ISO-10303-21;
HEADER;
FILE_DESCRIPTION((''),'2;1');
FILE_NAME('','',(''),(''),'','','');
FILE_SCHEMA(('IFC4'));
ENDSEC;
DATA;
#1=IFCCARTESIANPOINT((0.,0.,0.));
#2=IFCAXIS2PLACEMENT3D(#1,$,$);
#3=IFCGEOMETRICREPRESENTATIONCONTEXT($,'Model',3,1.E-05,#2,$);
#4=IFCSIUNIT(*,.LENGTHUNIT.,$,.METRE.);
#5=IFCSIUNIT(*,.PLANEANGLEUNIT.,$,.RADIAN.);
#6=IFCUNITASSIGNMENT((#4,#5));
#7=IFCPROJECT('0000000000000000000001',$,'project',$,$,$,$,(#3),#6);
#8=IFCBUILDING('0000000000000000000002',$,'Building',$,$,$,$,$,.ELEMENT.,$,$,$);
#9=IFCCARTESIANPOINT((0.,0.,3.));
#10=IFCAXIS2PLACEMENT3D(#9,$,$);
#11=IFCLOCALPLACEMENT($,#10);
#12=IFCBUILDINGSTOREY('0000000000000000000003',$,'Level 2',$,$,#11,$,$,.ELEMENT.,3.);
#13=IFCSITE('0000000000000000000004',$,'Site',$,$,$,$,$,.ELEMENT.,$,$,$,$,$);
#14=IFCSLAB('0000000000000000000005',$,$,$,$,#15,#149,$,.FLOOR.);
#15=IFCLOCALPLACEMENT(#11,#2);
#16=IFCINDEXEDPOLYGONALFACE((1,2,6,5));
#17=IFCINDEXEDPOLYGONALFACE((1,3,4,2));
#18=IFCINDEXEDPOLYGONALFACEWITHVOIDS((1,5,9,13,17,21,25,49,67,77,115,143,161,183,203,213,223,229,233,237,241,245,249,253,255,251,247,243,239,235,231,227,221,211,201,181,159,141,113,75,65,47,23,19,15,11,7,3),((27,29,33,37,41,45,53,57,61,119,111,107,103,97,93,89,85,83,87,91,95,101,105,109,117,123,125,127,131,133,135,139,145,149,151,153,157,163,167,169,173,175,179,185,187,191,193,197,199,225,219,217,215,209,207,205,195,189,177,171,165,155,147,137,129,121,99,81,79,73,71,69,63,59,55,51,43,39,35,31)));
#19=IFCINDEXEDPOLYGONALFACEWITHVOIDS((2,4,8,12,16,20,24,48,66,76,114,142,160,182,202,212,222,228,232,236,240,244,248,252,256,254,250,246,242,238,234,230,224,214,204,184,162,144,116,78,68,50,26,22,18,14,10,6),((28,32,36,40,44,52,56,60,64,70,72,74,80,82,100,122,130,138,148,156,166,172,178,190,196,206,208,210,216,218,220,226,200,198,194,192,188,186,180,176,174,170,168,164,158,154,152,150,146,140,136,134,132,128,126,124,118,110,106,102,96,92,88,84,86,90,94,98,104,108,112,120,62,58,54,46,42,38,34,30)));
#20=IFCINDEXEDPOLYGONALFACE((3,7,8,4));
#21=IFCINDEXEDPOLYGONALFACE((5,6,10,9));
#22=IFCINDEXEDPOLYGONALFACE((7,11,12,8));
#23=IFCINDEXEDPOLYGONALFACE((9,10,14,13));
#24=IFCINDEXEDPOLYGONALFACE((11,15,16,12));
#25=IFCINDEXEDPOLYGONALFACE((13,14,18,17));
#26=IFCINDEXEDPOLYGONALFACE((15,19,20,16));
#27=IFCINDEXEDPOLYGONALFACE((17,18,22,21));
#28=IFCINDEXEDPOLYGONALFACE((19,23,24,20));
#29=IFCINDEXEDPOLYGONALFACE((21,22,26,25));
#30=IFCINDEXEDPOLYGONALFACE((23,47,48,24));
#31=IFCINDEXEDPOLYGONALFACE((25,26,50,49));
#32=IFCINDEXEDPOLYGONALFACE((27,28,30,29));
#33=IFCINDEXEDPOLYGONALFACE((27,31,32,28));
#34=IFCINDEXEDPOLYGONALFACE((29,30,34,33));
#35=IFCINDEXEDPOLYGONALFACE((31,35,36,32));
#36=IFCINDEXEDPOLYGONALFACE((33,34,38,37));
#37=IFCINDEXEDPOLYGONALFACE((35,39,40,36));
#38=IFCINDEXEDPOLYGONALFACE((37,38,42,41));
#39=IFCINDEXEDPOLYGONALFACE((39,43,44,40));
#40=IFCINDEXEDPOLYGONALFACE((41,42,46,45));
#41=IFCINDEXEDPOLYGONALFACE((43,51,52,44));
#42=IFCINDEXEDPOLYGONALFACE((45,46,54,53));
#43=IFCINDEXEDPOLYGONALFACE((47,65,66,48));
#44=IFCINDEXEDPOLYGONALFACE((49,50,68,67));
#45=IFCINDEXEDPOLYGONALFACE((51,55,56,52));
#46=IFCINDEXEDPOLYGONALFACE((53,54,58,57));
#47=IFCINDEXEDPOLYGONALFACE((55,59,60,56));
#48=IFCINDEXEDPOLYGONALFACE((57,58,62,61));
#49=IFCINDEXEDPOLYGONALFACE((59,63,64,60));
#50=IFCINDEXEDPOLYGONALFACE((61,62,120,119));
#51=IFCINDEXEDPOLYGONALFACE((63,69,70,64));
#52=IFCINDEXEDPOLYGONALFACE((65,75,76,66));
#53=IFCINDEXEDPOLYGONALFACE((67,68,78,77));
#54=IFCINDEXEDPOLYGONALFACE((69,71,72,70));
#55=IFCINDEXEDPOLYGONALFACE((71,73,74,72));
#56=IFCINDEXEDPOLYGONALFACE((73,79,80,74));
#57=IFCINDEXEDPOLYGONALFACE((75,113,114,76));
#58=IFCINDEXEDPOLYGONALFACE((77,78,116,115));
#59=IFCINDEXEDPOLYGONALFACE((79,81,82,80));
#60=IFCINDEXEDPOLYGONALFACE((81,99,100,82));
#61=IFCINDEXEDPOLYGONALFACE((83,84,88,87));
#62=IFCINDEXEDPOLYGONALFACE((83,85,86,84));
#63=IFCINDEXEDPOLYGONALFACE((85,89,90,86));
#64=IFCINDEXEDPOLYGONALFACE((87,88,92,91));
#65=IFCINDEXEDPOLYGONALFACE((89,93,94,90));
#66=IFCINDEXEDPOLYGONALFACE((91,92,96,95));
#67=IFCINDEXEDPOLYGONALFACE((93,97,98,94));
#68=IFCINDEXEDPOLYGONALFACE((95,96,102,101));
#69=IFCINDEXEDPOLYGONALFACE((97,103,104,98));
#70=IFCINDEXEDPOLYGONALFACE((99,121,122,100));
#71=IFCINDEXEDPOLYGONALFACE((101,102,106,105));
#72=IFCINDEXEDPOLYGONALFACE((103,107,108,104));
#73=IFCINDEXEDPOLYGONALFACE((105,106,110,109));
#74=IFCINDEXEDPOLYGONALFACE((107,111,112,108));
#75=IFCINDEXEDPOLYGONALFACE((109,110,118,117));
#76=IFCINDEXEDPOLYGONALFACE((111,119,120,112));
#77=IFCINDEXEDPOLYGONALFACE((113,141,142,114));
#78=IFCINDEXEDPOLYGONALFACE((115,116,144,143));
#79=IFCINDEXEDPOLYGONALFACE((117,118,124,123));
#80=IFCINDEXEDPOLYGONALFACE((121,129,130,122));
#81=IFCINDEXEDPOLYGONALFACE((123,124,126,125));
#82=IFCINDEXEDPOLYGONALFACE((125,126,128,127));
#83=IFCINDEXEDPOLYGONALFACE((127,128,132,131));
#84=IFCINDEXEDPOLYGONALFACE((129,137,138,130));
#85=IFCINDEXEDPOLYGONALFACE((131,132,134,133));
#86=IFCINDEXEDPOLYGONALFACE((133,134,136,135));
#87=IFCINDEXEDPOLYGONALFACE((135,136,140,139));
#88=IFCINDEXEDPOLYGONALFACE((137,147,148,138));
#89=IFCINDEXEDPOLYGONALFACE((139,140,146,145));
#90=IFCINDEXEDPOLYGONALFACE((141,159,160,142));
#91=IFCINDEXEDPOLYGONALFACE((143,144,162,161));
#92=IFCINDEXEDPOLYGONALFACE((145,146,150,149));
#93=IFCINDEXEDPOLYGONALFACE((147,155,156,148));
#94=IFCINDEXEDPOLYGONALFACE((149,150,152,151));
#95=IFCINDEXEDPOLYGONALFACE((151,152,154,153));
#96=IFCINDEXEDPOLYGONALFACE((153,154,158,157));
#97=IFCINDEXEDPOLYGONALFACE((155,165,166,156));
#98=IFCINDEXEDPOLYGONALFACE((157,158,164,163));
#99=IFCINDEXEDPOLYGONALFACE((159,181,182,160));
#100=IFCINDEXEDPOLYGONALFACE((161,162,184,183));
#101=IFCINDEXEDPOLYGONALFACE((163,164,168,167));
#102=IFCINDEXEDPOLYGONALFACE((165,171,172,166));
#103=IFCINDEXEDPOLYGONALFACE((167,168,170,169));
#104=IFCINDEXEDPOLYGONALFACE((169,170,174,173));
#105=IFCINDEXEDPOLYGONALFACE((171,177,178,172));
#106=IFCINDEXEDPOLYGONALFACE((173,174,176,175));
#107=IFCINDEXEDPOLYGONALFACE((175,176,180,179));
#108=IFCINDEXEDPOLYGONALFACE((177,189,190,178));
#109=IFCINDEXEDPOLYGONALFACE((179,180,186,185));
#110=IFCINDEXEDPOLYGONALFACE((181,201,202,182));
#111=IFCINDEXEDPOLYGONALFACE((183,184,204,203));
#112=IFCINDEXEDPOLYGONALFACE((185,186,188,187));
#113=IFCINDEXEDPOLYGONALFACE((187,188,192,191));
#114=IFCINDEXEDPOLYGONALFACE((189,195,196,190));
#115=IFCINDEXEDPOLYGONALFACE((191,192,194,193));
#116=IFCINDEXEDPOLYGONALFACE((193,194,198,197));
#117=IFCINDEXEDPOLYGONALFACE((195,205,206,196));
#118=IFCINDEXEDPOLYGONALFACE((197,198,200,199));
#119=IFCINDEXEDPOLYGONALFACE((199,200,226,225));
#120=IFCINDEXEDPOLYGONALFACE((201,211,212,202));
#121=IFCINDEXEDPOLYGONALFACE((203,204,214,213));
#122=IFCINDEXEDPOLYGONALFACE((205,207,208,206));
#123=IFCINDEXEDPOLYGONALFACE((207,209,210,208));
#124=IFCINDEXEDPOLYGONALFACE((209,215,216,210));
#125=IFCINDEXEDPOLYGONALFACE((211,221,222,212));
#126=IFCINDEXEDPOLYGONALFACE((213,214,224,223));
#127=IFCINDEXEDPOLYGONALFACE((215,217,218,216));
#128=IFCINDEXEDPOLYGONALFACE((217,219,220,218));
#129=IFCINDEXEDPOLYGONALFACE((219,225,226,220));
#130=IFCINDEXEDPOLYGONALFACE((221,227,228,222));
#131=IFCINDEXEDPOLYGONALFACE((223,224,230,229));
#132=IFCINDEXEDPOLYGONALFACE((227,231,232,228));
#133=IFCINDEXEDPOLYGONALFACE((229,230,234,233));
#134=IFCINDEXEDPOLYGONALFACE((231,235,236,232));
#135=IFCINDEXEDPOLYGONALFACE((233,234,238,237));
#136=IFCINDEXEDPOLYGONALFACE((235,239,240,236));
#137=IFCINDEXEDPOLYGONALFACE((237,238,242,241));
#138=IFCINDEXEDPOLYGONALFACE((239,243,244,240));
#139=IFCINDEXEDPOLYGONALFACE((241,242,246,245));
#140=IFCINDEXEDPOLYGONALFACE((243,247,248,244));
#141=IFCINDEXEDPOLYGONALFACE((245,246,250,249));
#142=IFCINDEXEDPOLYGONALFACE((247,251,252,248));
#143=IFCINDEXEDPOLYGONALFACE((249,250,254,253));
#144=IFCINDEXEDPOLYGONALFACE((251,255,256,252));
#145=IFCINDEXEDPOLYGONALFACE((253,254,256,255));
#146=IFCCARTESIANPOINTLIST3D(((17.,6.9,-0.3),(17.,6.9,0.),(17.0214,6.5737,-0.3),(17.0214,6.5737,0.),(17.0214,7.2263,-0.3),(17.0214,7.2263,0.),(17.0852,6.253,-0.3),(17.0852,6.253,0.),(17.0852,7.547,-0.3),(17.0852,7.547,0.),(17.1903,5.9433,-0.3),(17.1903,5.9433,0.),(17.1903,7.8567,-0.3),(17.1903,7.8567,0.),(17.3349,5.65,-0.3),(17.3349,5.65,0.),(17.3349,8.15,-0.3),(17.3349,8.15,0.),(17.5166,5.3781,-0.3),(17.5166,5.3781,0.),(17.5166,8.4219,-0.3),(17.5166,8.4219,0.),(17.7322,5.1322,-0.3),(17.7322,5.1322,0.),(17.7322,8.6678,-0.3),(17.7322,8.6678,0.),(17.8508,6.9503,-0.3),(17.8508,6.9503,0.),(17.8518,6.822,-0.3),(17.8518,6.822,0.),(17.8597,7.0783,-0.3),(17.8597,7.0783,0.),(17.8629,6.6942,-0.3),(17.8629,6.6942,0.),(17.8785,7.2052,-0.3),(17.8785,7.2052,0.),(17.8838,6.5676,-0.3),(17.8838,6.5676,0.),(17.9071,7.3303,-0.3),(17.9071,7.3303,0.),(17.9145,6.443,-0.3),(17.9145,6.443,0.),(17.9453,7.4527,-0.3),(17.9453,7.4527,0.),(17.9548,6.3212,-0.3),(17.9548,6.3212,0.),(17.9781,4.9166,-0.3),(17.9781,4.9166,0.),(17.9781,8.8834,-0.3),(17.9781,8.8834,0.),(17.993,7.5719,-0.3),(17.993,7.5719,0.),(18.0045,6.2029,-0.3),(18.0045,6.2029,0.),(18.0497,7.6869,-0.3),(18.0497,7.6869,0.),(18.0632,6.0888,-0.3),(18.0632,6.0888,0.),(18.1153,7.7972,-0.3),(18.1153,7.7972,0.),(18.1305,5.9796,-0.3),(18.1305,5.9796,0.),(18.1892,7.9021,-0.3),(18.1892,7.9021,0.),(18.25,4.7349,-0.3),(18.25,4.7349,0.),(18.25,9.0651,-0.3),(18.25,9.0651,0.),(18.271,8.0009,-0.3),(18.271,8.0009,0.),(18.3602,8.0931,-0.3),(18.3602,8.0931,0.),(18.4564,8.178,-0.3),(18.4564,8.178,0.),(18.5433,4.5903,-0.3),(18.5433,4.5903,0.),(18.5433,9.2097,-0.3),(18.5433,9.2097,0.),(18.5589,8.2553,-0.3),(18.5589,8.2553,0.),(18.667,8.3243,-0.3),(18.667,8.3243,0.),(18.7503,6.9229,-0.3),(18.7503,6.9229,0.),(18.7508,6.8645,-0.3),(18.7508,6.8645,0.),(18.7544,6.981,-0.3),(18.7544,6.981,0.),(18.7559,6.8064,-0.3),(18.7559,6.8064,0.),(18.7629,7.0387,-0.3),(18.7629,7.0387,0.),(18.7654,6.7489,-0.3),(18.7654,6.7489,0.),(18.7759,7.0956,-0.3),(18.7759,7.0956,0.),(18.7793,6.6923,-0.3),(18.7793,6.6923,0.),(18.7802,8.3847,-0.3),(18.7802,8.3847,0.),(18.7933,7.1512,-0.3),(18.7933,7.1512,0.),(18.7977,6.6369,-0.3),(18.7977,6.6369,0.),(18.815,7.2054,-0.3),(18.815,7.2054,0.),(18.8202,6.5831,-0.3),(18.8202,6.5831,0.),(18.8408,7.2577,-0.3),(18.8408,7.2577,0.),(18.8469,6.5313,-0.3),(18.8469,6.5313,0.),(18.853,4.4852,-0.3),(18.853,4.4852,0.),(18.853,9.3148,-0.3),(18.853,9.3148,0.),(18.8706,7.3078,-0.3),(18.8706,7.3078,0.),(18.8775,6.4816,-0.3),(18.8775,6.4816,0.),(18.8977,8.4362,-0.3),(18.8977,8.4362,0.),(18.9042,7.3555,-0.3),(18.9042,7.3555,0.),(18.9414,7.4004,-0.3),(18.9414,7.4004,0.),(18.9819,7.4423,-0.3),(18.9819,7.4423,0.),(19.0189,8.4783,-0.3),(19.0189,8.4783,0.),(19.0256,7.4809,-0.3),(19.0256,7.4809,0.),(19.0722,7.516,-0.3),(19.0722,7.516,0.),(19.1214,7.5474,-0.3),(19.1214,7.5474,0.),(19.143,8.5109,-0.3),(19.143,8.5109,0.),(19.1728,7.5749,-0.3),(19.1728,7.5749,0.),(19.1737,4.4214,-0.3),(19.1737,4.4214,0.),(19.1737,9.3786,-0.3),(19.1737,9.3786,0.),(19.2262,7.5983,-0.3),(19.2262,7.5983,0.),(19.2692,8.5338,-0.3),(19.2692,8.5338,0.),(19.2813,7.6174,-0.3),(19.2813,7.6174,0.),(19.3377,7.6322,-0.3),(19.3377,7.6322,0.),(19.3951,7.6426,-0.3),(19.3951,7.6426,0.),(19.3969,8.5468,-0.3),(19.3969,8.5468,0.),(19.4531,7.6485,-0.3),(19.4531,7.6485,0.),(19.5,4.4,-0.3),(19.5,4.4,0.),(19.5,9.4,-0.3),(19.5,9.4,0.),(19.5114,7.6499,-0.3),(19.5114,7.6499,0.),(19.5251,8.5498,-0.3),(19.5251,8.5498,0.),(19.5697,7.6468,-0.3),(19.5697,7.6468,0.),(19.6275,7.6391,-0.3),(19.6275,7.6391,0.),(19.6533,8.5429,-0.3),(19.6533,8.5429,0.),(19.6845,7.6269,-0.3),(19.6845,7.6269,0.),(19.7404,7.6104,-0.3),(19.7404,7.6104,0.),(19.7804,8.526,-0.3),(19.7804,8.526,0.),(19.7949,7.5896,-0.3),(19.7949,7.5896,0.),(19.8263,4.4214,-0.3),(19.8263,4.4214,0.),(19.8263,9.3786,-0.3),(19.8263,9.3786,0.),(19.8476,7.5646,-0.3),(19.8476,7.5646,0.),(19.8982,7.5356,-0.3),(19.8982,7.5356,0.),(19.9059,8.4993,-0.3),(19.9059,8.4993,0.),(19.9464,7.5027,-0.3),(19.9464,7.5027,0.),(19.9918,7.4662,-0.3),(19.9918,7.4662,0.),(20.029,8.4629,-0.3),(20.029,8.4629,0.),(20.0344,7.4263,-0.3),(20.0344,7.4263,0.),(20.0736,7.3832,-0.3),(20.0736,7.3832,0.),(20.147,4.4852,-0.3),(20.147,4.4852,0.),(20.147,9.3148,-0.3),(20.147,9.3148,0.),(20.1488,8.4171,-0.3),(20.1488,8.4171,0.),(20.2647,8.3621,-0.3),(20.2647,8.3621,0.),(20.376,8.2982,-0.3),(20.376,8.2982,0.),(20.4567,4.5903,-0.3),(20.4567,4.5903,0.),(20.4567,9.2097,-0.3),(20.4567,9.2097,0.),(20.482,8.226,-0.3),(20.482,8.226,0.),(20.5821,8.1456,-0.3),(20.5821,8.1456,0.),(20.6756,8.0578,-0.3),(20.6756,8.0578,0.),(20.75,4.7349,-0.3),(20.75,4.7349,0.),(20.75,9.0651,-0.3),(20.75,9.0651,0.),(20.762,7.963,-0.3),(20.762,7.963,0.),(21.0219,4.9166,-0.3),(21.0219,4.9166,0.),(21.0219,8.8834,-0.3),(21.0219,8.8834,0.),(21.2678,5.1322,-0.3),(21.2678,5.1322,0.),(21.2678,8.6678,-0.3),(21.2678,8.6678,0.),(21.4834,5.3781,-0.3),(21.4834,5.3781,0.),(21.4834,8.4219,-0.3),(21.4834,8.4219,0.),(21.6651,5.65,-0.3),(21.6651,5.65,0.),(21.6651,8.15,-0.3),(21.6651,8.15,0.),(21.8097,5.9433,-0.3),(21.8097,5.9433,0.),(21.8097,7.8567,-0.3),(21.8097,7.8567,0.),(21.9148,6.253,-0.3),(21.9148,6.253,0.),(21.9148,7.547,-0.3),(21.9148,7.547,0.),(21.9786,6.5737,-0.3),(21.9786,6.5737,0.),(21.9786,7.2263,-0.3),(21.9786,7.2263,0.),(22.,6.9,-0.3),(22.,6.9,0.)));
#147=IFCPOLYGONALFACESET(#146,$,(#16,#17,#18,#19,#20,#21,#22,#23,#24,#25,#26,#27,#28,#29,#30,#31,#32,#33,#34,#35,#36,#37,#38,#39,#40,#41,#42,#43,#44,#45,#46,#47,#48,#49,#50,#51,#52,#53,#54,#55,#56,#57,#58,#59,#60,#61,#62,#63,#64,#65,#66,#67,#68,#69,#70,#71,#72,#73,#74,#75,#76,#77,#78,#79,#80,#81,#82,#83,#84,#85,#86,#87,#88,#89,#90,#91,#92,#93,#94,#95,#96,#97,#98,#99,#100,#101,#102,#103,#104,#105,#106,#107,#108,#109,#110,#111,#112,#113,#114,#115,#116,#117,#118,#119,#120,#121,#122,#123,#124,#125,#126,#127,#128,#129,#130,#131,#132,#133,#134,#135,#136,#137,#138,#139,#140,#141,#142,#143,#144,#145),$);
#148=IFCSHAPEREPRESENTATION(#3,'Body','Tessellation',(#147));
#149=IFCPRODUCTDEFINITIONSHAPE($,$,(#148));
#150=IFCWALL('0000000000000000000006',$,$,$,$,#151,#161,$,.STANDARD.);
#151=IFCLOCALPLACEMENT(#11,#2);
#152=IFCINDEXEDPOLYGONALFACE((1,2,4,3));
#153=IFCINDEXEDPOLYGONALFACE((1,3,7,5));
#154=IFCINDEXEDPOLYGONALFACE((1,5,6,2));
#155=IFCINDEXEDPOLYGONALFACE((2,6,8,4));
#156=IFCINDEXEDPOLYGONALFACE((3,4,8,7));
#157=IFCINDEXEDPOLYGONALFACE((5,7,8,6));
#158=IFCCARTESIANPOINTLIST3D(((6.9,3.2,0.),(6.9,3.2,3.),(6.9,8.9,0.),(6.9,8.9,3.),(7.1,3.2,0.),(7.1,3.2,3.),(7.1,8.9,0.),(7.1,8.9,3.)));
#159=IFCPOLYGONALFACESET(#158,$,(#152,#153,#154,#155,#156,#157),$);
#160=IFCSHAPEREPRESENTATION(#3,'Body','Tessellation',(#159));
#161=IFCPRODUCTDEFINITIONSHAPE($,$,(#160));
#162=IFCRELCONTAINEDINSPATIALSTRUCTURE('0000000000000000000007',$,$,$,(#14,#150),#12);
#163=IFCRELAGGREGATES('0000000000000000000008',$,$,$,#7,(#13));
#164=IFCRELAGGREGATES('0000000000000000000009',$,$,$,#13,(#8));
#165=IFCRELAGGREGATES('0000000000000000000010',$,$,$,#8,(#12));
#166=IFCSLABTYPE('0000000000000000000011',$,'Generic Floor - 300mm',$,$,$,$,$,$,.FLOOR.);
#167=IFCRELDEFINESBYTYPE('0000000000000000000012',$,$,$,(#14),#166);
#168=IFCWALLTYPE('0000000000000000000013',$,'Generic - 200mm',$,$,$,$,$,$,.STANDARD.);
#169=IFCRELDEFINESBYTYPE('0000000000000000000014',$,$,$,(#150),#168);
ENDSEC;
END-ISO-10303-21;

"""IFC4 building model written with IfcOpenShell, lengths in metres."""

from ifc_helpers import new_model, si_unit, frame, origin, place, context, project, spatial, polyline, outline, extrude, type_object, element, save


model = new_model("IFC4")

# Units and contexts
model_context = context("Model", 3, precision=1e-05, world=origin())
ifc_project = project(units=[si_unit("LENGTHUNIT", "METRE"), si_unit("PLANEANGLEUNIT", "RADIAN")], contexts=[model_context])

# Site, building, storey
site = spatial("IfcSite", under=ifc_project, Name="Site", CompositionType="ELEMENT")
building = spatial("IfcBuilding", under=site, Name="Building", CompositionType="ELEMENT")
storey_placement = place(None, frame((0.0, 0.0, 3.0)))
storey = spatial("IfcBuildingStorey", under=building, at=storey_placement, Name="Level 2", CompositionType="ELEMENT", Elevation=3.0)

# Shared definitions
slab_type = type_object("IfcSlabType", Name="Generic Floor - 300mm", PredefinedType="FLOOR")

# Slab, opening
slab_1_placement = place(None, frame((0.0, 0.0, 3.0)))
slab_1 = element("IfcSlab", 1, at=slab_1_placement, inside=storey, type_object=slab_type, PredefinedType="FLOOR", context=model_context, shape_type="SweptSolid", body=[
    extrude(outline(polyline([(22.0, 6.9), (21.9786, 7.2263), (21.9148, 7.547), (21.8097, 7.8567), (21.6651, 8.15), (21.4834, 8.4219), (21.2678, 8.6678), (21.0219, 8.8834), (20.75, 9.0651), (20.4567, 9.2097), (20.147, 9.3148), (19.8263, 9.3786), (19.5, 9.4), (19.1737, 9.3786), (18.853, 9.3148), (18.5433, 9.2097), (18.25, 9.0651), (17.9781, 8.8834), (17.7322, 8.6678), (17.5166, 8.4219), (17.3349, 8.15), (17.1903, 7.8567), (17.0852, 7.547), (17.0214, 7.2263), (17.0, 6.9), (17.0214, 6.5737), (17.0852, 6.253), (17.1903, 5.9433), (17.3349, 5.65), (17.5166, 5.3781), (17.7322, 5.1322), (17.9781, 4.9166), (18.25, 4.7349), (18.5433, 4.5903), (18.853, 4.4852), (19.1737, 4.4214), (19.5, 4.4), (19.8263, 4.4214), (20.147, 4.4852), (20.4567, 4.5903), (20.75, 4.7349), (21.0219, 4.9166), (21.2678, 5.1322), (21.4834, 5.3781), (21.6651, 5.65), (21.8097, 5.9433), (21.9148, 6.253), (21.9786, 6.5737), (22.0, 6.9)])), origin(), (0.0, 0.0, -1.0), 0.3),
])
opening_1_placement = place(None, frame((0.0, 0.0, 3.001)))
element("IfcOpeningElement", 2, at=opening_1_placement, cuts=slab_1, PredefinedType="OPENING", context=model_context, shape_type="SweptSolid", body=[
    extrude(outline(polyline([(17.8597, 7.0783), (17.8508, 6.9503), (17.8518, 6.822), (17.8629, 6.6942), (17.8838, 6.5676), (17.9145, 6.443), (17.9548, 6.3212), (18.0045, 6.2029), (18.0632, 6.0888), (18.1305, 5.9796), (18.8775, 6.4816), (18.8469, 6.5313), (18.8202, 6.5831), (18.7977, 6.6369), (18.7793, 6.6923), (18.7654, 6.7489), (18.7559, 6.8064), (18.7508, 6.8645), (18.7503, 6.9229), (18.7544, 6.981), (18.7629, 7.0387), (18.7759, 7.0956), (18.7933, 7.1512), (18.815, 7.2054), (18.8408, 7.2577), (18.8706, 7.3078), (18.9042, 7.3555), (18.9414, 7.4004), (18.9819, 7.4423), (19.0256, 7.4809), (19.0722, 7.516), (19.1214, 7.5474), (19.1728, 7.5749), (19.2262, 7.5983), (19.2813, 7.6174), (19.3377, 7.6322), (19.3951, 7.6426), (19.4531, 7.6485), (19.5114, 7.6499), (19.5697, 7.6468), (19.6275, 7.6391), (19.6845, 7.6269), (19.7404, 7.6104), (19.7949, 7.5896), (19.8476, 7.5646), (19.8982, 7.5356), (19.9464, 7.5027), (19.9918, 7.4662), (20.0344, 7.4263), (20.0736, 7.3832), (20.762, 7.963), (20.6756, 8.0578), (20.5821, 8.1456), (20.482, 8.226), (20.376, 8.2982), (20.2647, 8.3621), (20.1488, 8.4171), (20.029, 8.4629), (19.9059, 8.4993), (19.7804, 8.526), (19.6533, 8.5429), (19.5251, 8.5498), (19.3969, 8.5468), (19.2692, 8.5338), (19.143, 8.5109), (19.0189, 8.4783), (18.8977, 8.4362), (18.7802, 8.3847), (18.667, 8.3243), (18.5589, 8.2553), (18.4564, 8.178), (18.3602, 8.0931), (18.271, 8.0009), (18.1892, 7.9021), (18.1153, 7.7972), (18.0497, 7.6869), (17.993, 7.5719), (17.9453, 7.4527), (17.9071, 7.3303), (17.8785, 7.2052), (17.8597, 7.0783)])), origin(), (0.0, 0.0, -1.0), 0.302),
])

# Wall
wall_type = type_object("IfcWallType", Name="Generic - 200mm", PredefinedType="STANDARD")
wall_placement = place(None, frame((7.0, 3.2, 3.0), z_axis=(0.0, 0.0, 1.0), x_axis=(0.0, 1.0, 0.0)))
element("IfcWall", 3, at=wall_placement, inside=storey, type_object=wall_type, PredefinedType="STANDARD", context=model_context, shape_type="SweptSolid", body=[
    extrude(outline(polyline([(0.0, -0.1), (5.7, -0.1), (5.7, 0.1), (0.0, 0.1), (0.0, -0.1)])), origin(), (0.0, 0.0, 1.0), 3.0),
])

save(model, "model.ifc")
